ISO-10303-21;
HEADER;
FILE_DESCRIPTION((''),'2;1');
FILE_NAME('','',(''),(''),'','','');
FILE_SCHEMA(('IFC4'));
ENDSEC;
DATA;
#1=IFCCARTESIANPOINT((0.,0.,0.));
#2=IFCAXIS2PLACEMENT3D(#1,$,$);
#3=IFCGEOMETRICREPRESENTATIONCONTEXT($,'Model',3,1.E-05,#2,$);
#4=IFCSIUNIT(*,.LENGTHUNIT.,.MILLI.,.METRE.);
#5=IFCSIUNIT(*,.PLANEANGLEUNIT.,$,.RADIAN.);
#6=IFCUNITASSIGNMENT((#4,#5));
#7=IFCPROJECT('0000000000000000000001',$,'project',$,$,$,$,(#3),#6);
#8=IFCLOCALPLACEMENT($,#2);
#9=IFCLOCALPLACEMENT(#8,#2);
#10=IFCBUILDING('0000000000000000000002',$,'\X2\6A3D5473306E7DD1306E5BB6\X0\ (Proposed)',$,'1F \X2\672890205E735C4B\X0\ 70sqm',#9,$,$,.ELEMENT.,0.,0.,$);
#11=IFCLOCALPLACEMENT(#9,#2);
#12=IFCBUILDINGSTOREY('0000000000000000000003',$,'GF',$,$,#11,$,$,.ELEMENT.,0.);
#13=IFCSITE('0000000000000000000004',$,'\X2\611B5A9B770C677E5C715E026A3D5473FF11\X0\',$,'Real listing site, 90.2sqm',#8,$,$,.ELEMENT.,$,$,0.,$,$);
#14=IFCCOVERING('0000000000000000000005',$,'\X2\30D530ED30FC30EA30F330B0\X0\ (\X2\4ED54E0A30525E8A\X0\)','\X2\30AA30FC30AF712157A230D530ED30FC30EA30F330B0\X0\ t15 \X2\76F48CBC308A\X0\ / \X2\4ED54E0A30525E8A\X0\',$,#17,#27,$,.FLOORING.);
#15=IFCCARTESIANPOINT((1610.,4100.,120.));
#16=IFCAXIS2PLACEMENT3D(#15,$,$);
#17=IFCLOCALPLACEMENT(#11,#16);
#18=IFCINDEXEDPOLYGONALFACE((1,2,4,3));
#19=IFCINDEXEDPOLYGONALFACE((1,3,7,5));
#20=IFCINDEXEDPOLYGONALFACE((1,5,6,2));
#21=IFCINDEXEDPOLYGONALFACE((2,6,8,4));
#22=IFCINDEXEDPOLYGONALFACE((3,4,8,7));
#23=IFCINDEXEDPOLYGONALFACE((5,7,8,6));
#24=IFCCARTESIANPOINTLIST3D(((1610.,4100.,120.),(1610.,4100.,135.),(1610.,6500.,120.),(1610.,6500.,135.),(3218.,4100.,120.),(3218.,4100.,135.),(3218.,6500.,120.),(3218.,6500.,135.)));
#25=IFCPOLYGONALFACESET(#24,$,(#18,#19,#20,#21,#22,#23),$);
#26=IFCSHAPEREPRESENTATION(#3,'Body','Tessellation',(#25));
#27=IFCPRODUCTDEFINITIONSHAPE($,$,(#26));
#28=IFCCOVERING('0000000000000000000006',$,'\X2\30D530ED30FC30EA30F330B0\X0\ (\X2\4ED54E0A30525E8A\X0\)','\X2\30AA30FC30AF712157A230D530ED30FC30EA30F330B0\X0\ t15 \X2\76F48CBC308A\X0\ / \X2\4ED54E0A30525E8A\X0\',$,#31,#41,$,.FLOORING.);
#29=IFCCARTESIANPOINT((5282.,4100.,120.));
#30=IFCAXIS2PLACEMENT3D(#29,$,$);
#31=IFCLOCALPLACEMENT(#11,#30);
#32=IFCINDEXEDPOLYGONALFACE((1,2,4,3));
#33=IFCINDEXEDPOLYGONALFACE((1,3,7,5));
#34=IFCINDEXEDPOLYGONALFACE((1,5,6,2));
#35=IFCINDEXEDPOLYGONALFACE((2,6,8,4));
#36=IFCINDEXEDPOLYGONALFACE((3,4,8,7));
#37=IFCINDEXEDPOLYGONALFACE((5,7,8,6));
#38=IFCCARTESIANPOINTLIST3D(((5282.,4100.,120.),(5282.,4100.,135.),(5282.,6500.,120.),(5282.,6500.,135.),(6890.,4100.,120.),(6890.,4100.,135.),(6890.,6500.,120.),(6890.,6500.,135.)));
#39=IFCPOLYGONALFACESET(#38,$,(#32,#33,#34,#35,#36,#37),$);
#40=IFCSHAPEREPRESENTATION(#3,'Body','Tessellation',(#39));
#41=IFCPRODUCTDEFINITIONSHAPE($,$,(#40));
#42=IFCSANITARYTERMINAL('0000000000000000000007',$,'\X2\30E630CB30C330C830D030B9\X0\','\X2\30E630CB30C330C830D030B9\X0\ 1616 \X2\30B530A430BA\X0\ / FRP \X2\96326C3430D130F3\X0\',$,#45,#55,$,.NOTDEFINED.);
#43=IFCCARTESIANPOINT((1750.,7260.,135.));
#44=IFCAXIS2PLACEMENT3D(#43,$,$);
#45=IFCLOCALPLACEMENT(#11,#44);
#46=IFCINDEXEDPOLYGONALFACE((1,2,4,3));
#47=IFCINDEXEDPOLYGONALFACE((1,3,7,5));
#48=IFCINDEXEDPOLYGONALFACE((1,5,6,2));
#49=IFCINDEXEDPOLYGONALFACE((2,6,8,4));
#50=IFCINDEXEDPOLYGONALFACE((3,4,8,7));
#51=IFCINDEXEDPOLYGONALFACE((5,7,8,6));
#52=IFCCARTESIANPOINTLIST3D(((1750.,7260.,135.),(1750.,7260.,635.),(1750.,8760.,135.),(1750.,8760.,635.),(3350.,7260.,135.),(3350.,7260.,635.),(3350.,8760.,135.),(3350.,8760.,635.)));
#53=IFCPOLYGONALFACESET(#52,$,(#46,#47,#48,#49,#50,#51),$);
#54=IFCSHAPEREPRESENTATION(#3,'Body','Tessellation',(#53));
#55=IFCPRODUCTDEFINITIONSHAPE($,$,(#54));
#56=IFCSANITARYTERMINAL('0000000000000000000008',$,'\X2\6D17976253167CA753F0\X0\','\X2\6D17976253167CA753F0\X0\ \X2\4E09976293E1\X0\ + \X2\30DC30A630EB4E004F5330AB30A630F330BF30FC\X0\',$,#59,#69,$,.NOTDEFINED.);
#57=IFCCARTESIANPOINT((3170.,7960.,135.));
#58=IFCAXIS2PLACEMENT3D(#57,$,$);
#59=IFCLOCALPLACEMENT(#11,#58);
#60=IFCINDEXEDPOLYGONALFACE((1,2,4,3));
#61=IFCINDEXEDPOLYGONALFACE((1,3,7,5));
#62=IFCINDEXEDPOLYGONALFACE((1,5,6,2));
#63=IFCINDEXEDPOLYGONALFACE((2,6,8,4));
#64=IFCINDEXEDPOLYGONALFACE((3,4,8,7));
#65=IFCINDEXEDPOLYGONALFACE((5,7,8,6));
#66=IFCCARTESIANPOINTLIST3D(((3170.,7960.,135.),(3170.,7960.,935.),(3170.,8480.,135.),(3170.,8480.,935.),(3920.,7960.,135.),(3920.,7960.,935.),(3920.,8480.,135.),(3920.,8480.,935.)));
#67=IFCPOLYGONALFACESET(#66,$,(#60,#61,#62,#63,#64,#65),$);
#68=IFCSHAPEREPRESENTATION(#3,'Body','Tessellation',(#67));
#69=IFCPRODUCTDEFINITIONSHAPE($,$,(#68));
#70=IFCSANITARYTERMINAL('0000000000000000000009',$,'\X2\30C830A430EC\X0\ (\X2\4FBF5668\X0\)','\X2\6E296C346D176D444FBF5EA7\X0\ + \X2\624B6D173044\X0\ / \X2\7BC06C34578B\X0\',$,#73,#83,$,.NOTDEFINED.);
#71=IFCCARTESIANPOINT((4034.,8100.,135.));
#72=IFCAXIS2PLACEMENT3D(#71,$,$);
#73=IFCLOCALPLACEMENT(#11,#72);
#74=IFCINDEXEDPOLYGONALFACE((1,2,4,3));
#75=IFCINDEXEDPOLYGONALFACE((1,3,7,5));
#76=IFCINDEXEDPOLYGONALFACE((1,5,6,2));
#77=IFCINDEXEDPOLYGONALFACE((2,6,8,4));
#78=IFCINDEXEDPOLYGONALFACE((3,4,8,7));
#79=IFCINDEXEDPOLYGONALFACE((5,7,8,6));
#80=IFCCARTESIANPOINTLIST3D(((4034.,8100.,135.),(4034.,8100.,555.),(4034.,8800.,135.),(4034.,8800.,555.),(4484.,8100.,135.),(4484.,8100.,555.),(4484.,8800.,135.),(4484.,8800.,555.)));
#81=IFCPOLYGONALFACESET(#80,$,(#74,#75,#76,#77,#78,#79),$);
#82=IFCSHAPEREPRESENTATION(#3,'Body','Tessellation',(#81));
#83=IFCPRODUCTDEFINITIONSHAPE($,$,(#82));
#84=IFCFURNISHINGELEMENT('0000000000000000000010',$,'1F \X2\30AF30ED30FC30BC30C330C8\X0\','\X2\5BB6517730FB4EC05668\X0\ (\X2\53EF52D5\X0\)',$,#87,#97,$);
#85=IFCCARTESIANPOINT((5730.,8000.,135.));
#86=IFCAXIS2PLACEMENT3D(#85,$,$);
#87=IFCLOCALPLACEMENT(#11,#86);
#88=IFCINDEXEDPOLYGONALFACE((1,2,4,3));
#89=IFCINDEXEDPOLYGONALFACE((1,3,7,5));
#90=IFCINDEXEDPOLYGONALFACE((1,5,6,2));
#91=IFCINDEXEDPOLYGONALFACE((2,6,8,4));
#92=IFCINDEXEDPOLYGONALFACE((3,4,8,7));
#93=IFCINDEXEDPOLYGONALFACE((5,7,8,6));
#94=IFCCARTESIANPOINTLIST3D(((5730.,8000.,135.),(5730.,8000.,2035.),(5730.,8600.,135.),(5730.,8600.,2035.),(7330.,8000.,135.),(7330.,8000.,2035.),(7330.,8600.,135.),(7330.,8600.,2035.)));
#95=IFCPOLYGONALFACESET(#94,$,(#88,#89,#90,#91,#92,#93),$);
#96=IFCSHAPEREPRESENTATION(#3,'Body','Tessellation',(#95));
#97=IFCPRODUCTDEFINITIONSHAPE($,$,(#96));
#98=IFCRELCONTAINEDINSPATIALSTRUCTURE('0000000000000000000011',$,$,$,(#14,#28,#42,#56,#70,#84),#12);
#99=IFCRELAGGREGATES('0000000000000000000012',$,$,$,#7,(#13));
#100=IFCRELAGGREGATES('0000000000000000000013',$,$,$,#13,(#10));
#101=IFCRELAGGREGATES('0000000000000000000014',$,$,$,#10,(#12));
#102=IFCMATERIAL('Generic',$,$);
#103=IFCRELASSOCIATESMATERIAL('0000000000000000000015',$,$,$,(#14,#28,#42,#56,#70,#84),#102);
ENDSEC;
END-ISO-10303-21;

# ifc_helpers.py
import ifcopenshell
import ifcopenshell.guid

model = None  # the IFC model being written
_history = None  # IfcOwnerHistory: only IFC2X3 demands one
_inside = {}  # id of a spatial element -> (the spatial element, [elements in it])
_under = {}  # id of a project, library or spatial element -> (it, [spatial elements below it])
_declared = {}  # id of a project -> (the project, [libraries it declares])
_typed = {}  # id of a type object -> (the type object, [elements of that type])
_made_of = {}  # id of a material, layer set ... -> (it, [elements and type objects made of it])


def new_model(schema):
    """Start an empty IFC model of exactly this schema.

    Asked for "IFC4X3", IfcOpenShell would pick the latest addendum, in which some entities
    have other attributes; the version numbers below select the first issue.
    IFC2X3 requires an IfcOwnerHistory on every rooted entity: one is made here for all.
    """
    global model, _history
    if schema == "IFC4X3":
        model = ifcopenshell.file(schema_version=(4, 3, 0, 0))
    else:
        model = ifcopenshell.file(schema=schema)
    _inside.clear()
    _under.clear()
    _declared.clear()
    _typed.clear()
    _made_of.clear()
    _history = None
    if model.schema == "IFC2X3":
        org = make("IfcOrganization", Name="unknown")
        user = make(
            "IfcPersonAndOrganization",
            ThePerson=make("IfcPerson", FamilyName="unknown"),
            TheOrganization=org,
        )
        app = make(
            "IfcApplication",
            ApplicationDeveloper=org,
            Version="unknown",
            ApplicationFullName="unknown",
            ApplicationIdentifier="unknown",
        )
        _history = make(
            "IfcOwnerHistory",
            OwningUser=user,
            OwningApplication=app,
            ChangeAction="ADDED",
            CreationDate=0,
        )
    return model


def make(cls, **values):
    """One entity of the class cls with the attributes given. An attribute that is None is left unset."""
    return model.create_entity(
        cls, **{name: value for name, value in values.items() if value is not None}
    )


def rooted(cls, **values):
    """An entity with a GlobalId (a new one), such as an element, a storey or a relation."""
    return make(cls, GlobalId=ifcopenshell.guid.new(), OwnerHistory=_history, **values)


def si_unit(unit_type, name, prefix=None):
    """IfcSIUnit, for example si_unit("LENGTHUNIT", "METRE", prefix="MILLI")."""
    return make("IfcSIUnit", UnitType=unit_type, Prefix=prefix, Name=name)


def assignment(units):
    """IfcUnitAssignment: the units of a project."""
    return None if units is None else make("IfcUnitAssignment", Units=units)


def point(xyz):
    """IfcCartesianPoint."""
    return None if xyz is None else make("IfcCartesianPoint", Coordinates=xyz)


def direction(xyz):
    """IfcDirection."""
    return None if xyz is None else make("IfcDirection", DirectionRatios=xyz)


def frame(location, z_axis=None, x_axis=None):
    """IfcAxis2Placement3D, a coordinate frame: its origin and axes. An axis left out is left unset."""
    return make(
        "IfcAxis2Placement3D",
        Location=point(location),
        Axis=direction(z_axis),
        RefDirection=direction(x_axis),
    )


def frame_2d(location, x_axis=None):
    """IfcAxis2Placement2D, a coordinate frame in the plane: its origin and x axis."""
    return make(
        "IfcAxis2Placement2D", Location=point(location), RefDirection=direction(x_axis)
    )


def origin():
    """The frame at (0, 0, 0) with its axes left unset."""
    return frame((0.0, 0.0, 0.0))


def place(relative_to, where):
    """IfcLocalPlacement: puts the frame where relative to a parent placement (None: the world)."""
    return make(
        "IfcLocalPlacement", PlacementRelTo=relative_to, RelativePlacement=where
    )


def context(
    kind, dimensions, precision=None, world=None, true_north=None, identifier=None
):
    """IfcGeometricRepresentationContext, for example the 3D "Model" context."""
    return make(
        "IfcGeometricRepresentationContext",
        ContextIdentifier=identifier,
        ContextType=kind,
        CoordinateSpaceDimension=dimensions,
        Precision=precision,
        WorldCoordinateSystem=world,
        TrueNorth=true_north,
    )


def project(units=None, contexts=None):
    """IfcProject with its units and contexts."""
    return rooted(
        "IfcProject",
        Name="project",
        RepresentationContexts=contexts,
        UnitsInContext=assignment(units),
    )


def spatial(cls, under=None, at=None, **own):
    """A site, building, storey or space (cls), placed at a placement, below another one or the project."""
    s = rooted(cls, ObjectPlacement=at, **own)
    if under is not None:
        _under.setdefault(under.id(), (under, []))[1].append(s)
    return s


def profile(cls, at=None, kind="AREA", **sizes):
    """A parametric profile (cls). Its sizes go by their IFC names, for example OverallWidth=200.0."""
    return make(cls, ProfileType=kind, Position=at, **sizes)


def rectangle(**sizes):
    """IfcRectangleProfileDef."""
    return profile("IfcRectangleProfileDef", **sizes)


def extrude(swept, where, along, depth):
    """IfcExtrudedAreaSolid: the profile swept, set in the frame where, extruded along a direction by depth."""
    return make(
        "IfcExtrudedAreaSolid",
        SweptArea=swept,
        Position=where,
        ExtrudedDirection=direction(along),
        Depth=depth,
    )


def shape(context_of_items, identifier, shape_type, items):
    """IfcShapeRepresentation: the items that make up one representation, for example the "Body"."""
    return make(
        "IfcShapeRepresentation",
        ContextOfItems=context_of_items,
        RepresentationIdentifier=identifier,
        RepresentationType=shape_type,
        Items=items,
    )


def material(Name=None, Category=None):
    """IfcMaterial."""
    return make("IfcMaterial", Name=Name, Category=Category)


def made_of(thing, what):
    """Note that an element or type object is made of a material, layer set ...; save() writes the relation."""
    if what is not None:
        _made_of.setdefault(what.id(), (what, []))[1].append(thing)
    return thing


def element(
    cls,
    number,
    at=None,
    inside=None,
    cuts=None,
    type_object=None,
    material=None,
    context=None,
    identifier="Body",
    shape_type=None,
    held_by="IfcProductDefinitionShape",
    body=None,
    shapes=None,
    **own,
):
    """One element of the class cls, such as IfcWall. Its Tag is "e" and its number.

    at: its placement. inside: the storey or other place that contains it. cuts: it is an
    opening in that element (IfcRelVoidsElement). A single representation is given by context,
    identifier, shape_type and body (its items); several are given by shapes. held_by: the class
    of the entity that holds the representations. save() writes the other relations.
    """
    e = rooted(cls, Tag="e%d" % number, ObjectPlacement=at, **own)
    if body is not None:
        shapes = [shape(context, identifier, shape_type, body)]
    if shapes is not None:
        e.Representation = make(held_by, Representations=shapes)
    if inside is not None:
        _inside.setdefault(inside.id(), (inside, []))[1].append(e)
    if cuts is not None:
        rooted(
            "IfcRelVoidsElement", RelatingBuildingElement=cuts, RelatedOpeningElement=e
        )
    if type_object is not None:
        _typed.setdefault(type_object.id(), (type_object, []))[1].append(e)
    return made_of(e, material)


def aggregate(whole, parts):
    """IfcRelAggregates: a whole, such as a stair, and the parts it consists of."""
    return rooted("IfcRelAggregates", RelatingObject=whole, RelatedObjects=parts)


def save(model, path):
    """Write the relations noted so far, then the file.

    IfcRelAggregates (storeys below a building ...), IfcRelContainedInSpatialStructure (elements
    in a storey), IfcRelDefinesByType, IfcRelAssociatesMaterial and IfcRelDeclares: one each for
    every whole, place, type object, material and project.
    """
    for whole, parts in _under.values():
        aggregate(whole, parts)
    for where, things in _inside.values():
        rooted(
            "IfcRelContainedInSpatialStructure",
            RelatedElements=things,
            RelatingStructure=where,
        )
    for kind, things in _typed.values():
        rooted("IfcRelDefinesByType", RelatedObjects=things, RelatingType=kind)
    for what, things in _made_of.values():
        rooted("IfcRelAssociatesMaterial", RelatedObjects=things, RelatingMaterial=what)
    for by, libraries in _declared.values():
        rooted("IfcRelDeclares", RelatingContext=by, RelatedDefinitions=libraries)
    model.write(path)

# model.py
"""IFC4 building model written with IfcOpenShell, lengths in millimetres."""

from ifc_helpers import new_model, si_unit, frame, frame_2d, origin, place, context, project, spatial, rectangle, extrude, material, element, save


model = new_model("IFC4")

# Units and contexts
model_context = context("Model", 3, precision=1e-05, world=origin())
ifc_project = project(units=[si_unit("LENGTHUNIT", "METRE", prefix="MILLI"), si_unit("PLANEANGLEUNIT", "RADIAN")], contexts=[model_context])

# Site, building, storey
site_placement = place(None, origin())
site = spatial("IfcSite", under=ifc_project, at=site_placement, Name="愛媛県松山市樽味１", ObjectType="Real listing site, 90.2sqm", CompositionType="ELEMENT", RefElevation=0.0)
building_placement = place(site_placement, origin())
building = spatial("IfcBuilding", under=site, at=building_placement, Name="樽味の緑の家 (Proposed)", ObjectType="1F 木造平屋 70sqm", CompositionType="ELEMENT", ElevationOfRefHeight=0.0, ElevationOfTerrain=0.0)
storey_placement = place(building_placement, origin())
storey = spatial("IfcBuildingStorey", under=building, at=storey_placement, Name="GF", CompositionType="ELEMENT", Elevation=0.0)

# Coverings
ifc_material_1 = material(Name="Generic")
covering_1_placement = place(storey_placement, frame((1610.0, 4100.0, 120.0)))
element("IfcCovering", 1, at=covering_1_placement, inside=storey, material=ifc_material_1, Name="フローリング (仕上げ床)", Description="オーク無垢フローリング t15 直貼り / 仕上げ床", PredefinedType="FLOORING", context=model_context, shape_type="SweptSolid", body=[
    extrude(rectangle(XDim=1608.0, YDim=2400.0, at=frame_2d((804.0, 1200.0))), frame((1610.0, 4100.0, 120.0)), (0.0, 0.0, 1.0), 15.0),
])
covering_2_placement = place(storey_placement, frame((5282.0, 4100.0, 120.0)))
element("IfcCovering", 2, at=covering_2_placement, inside=storey, material=ifc_material_1, Name="フローリング (仕上げ床)", Description="オーク無垢フローリング t15 直貼り / 仕上げ床", PredefinedType="FLOORING", context=model_context, shape_type="SweptSolid", body=[
    extrude(rectangle(XDim=1608.0, YDim=2400.0, at=frame_2d((804.0, 1200.0))), frame((5282.0, 4100.0, 120.0)), (0.0, 0.0, 1.0), 15.0),
])

# Sanitary terminals
sanitary_terminal_1_placement = place(storey_placement, frame((1750.0, 7260.0, 135.0)))
element("IfcSanitaryTerminal", 3, at=sanitary_terminal_1_placement, inside=storey, material=ifc_material_1, Name="ユニットバス", Description="ユニットバス 1616 サイズ / FRP 防水パン", PredefinedType="NOTDEFINED", context=model_context, shape_type="SweptSolid", body=[
    extrude(rectangle(XDim=1600.0, YDim=1500.0, at=frame_2d((800.0, 750.0))), frame((1750.0, 7260.0, 135.0)), (0.0, 0.0, 1.0), 500.0),
])
sanitary_terminal_2_placement = place(storey_placement, frame((3170.0, 7960.0, 135.0)))
element("IfcSanitaryTerminal", 4, at=sanitary_terminal_2_placement, inside=storey, material=ifc_material_1, Name="洗面化粧台", Description="洗面化粧台 三面鏡 + ボウル一体カウンター", PredefinedType="NOTDEFINED", context=model_context, shape_type="SweptSolid", body=[
    extrude(rectangle(XDim=750.0, YDim=520.0, at=frame_2d((375.0, 260.0))), frame((3170.0, 7960.0, 135.0)), (0.0, 0.0, 1.0), 800.0),
])
sanitary_terminal_3_placement = place(storey_placement, frame((4034.0, 8100.0, 135.0)))
element("IfcSanitaryTerminal", 5, at=sanitary_terminal_3_placement, inside=storey, material=ifc_material_1, Name="トイレ (便器)", Description="温水洗浄便座 + 手洗い / 節水型", PredefinedType="NOTDEFINED", context=model_context, shape_type="SweptSolid", body=[
    extrude(rectangle(XDim=450.0, YDim=700.0, at=frame_2d((225.0, 350.0))), frame((4034.0, 8100.0, 135.0)), (0.0, 0.0, 1.0), 420.0),
])

# Furnishing element
furnishing_placement = place(storey_placement, frame((5730.0, 8000.0, 135.0)))
element("IfcFurnishingElement", 6, at=furnishing_placement, inside=storey, material=ifc_material_1, Name="1F クローゼット", Description="家具・什器 (可動)", context=model_context, shape_type="SweptSolid", body=[
    extrude(rectangle(XDim=1600.0, YDim=600.0, at=frame_2d((800.0, 300.0))), frame((5730.0, 8000.0, 135.0)), (0.0, 0.0, 1.0), 1900.0),
])

save(model, "model.ifc")
